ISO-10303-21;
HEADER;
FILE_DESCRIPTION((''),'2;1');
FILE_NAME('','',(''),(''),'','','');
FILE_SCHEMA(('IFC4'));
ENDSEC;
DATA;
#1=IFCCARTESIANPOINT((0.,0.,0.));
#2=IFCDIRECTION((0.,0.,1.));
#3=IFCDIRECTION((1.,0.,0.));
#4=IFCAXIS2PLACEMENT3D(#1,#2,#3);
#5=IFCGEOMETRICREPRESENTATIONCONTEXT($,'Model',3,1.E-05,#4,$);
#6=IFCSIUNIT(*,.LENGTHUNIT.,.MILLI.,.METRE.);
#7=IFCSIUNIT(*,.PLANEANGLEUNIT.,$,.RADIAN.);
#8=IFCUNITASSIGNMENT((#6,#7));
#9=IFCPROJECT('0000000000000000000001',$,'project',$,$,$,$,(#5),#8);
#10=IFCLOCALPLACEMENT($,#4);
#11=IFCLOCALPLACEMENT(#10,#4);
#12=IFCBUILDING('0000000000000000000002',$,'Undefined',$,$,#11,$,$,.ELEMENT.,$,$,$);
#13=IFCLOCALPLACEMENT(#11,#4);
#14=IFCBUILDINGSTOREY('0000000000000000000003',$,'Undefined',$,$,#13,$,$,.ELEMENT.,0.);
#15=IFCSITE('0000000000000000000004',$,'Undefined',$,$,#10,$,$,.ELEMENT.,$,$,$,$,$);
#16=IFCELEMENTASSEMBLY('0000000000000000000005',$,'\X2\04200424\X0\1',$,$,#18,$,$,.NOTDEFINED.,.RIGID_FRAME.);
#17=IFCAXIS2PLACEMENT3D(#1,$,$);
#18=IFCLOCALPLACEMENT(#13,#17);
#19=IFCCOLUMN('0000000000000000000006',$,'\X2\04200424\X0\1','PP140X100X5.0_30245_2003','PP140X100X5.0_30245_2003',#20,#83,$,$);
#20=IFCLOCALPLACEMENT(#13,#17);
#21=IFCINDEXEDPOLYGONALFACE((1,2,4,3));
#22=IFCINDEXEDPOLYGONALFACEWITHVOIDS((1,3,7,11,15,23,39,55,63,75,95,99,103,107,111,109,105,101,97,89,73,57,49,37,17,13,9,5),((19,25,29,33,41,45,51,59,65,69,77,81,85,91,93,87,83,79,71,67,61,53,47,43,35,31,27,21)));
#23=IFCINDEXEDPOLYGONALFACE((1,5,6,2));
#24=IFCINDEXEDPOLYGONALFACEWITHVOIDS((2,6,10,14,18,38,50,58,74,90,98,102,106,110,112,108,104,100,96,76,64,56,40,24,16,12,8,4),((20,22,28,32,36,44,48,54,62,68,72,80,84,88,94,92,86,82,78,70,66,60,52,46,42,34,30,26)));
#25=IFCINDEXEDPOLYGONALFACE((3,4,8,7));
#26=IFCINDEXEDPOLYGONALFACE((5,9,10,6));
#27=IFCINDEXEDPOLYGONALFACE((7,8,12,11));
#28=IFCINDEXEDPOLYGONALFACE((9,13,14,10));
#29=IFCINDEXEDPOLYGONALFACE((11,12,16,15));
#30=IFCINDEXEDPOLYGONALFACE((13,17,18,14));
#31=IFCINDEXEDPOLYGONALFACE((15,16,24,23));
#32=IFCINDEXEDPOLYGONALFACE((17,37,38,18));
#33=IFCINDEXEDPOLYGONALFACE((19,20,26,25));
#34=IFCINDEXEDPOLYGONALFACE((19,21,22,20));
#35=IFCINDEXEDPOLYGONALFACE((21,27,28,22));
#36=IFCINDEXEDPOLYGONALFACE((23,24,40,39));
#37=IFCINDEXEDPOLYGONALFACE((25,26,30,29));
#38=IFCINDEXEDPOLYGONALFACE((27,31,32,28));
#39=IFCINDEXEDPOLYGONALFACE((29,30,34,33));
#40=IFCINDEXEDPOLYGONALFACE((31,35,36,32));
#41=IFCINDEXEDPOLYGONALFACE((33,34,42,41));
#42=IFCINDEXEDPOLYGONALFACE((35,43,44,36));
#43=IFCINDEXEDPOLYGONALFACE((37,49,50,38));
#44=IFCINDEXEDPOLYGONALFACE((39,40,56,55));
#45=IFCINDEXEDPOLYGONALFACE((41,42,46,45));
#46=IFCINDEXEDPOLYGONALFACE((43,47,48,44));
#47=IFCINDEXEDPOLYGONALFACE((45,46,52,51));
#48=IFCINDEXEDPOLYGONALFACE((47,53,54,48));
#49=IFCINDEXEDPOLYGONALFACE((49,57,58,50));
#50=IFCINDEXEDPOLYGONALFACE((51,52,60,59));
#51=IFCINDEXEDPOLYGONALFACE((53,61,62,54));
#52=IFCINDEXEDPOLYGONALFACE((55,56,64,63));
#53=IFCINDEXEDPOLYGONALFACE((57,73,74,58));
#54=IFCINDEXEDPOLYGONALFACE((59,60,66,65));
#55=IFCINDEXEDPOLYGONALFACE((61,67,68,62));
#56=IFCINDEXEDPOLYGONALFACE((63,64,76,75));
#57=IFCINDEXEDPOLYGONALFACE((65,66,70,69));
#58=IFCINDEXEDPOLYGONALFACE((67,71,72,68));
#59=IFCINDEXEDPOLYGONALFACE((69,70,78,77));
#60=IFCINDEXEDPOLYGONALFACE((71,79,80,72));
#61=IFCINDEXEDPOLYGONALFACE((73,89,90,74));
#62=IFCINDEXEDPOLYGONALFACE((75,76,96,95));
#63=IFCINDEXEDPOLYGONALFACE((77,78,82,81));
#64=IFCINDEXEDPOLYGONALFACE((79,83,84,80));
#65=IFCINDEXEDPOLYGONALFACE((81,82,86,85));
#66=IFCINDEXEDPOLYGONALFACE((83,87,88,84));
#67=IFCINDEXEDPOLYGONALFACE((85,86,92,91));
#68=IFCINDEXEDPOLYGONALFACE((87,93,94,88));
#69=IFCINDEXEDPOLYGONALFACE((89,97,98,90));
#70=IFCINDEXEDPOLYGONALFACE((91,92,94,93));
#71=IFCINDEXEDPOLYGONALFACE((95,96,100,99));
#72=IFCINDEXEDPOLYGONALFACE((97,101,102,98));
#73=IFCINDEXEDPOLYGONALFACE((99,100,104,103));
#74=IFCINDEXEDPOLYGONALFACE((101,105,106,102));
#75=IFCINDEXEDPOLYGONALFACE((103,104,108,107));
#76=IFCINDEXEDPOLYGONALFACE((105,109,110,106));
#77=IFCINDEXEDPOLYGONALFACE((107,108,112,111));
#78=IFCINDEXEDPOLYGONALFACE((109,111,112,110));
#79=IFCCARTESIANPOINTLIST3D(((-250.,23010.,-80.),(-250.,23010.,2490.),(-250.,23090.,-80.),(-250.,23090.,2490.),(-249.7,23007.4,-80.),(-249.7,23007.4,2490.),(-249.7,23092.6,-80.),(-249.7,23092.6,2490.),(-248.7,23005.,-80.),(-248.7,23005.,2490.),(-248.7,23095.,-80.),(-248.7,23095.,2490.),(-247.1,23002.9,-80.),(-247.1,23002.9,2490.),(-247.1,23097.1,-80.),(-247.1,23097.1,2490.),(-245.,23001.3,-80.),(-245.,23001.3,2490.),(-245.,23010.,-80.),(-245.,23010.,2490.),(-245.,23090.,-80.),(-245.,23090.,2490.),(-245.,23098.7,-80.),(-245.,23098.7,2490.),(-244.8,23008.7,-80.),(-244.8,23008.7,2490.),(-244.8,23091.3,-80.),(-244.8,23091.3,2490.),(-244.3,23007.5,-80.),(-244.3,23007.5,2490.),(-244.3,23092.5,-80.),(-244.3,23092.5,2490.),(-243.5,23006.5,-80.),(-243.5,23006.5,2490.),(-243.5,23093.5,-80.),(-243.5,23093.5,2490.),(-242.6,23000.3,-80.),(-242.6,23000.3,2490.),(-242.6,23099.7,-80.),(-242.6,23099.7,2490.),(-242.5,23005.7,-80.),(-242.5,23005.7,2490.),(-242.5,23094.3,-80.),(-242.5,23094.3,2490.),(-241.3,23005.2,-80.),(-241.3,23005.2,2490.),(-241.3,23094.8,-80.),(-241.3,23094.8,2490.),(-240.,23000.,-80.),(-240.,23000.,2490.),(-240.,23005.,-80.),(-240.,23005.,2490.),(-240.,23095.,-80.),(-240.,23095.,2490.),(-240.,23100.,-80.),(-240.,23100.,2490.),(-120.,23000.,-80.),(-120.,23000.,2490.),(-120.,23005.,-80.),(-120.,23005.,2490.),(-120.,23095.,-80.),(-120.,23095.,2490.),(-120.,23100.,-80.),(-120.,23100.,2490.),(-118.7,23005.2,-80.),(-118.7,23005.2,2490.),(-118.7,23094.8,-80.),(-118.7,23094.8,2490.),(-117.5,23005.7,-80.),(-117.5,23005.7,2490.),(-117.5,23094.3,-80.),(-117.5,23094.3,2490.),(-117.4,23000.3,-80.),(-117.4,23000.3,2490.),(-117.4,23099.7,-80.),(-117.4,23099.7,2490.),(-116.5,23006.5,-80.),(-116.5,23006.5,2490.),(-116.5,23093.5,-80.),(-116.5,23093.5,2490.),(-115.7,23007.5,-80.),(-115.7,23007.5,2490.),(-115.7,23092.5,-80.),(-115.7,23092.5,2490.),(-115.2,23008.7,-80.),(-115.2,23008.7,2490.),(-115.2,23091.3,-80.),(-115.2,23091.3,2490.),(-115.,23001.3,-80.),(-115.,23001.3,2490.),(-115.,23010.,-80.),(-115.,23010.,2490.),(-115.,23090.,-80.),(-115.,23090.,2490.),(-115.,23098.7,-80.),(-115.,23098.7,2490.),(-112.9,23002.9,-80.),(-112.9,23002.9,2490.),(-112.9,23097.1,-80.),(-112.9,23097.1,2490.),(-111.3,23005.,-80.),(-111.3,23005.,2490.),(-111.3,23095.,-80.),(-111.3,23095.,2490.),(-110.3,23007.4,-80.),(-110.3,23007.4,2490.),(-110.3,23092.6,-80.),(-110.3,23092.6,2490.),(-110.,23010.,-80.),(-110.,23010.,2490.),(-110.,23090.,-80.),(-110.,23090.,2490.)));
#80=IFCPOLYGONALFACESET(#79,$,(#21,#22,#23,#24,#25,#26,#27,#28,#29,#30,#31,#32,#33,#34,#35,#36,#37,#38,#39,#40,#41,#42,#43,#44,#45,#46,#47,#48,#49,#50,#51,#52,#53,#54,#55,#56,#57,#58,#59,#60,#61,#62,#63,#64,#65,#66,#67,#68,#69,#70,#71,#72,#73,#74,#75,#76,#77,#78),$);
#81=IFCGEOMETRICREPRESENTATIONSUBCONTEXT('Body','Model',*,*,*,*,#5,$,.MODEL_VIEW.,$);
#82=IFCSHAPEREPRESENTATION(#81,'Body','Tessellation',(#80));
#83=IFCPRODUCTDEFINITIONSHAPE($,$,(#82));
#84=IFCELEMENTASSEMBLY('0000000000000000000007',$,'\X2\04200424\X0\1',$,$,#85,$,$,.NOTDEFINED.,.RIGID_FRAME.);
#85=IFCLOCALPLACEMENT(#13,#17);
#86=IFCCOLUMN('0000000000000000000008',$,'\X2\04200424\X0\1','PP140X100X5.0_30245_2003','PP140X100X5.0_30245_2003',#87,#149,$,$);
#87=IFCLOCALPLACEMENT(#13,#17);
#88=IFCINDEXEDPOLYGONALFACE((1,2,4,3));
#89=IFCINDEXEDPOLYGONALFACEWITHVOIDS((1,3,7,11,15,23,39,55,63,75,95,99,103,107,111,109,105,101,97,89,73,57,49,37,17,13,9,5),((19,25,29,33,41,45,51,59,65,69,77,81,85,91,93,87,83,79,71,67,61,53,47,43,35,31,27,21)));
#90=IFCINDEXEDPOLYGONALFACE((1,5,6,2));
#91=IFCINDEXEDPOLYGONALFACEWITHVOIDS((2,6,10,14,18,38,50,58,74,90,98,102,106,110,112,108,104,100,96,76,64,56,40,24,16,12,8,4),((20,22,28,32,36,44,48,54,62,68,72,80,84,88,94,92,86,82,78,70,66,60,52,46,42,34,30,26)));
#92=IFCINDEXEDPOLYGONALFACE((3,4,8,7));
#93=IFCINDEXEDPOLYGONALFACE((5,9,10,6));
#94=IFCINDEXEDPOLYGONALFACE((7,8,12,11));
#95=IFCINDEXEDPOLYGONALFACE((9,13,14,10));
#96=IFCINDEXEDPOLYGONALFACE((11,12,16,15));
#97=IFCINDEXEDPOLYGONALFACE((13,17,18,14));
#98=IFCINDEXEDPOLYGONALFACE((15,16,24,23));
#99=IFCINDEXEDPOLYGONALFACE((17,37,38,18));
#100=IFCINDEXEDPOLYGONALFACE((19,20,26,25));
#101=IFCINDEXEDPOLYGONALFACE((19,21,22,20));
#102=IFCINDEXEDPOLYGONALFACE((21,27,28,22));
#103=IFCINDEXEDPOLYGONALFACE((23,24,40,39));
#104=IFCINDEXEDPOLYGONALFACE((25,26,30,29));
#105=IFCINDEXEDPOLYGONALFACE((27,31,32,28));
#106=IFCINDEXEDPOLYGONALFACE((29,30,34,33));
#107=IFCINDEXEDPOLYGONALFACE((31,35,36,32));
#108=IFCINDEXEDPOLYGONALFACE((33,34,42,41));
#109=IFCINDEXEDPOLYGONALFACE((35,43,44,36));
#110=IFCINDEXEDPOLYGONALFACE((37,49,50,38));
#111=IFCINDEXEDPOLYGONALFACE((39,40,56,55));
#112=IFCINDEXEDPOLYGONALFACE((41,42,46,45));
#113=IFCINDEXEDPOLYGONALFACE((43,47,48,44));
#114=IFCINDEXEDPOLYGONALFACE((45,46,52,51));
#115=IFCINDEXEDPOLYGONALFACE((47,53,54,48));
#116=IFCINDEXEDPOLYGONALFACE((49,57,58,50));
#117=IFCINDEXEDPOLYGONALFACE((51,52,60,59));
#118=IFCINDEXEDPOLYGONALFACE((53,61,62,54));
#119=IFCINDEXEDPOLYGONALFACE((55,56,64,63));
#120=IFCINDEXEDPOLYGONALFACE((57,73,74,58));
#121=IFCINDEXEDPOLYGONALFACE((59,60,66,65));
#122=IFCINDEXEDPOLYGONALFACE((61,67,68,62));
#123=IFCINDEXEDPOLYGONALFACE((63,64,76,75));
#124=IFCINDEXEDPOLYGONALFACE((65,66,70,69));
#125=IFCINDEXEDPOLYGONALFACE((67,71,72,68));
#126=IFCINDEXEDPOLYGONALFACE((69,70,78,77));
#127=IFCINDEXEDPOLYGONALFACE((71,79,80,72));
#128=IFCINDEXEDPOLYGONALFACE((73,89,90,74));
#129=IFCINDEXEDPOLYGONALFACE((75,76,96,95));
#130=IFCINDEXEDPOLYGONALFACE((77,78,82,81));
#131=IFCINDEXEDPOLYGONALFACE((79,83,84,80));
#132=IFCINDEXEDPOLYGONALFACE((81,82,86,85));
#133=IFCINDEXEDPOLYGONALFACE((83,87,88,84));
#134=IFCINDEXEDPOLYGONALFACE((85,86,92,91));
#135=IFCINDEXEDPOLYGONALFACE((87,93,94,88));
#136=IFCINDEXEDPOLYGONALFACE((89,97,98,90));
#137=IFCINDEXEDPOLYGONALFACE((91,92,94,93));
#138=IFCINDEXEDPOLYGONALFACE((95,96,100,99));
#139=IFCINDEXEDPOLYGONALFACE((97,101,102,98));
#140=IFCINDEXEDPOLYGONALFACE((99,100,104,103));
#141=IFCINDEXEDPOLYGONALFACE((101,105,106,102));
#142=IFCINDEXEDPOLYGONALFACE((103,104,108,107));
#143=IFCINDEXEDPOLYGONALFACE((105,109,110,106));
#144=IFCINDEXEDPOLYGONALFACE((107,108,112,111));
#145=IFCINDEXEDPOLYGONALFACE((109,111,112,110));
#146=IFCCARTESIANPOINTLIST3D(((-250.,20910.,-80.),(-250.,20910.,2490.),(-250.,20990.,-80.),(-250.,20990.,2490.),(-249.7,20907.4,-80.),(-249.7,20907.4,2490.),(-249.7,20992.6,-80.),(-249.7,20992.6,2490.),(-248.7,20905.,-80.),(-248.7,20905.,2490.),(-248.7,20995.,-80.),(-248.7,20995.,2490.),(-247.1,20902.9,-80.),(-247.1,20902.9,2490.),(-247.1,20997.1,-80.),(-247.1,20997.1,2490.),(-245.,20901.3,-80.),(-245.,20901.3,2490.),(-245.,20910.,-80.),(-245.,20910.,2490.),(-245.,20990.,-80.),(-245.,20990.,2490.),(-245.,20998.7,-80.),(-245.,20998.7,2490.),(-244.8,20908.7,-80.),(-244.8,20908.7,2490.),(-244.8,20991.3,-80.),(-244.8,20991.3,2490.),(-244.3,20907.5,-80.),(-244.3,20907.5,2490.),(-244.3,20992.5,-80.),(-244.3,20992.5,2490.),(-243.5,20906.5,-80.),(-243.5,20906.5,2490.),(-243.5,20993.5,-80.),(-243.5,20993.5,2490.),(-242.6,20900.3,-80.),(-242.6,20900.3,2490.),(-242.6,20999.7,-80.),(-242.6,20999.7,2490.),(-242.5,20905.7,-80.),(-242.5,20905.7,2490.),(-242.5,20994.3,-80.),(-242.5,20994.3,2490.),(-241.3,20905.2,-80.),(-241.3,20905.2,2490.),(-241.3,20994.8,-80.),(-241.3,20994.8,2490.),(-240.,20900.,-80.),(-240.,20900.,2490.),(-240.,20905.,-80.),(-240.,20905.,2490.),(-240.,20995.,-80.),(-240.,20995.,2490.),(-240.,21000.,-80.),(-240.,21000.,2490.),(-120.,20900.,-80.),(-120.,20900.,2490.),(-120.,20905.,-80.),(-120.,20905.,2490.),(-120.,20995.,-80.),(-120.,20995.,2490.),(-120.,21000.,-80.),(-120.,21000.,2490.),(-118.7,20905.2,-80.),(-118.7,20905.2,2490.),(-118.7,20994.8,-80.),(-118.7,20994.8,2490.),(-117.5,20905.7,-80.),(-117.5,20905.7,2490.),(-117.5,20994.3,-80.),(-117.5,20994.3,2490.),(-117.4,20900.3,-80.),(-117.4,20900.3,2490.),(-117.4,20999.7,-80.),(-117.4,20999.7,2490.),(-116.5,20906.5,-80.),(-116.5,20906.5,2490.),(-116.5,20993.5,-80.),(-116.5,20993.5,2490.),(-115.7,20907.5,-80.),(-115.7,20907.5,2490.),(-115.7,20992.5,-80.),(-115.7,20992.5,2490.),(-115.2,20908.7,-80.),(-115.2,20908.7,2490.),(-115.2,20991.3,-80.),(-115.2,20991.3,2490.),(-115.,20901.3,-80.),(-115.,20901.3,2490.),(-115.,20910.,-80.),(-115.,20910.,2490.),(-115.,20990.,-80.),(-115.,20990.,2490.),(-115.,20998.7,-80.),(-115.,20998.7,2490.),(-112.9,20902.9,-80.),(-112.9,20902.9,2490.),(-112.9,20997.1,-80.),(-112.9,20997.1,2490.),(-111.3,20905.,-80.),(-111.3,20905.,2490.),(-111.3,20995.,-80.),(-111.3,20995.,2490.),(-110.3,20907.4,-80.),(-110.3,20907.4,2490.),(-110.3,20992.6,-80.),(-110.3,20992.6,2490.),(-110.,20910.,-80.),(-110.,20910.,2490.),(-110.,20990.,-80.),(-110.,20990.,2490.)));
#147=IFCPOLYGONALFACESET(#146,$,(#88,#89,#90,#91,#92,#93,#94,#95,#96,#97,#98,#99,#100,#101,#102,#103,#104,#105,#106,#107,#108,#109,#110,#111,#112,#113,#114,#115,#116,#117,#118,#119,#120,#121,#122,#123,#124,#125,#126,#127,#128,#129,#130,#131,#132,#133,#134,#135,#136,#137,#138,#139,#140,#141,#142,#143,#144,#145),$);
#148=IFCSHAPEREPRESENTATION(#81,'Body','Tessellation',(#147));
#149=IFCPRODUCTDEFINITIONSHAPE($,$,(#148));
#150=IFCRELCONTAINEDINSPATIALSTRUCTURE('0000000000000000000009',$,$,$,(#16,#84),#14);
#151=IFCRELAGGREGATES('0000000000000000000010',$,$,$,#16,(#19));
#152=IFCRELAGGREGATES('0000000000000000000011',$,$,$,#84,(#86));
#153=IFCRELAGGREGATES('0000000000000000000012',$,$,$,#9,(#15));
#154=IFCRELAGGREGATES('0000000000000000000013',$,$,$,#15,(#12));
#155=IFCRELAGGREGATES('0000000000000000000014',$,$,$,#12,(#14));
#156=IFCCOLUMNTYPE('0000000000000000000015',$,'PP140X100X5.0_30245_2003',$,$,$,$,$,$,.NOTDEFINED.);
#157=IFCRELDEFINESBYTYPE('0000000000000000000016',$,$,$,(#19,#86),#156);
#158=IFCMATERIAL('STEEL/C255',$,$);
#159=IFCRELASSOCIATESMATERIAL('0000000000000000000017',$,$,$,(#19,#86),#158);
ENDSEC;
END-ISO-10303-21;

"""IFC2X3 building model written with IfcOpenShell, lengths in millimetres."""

from ifc_helpers import new_model, si_unit, frame, origin_with_axes, origin_2d_with_axis, place, context, subcontext, project, spatial, hollow_rectangle, extrude, material, type_object, element, aggregate, save


model = new_model("IFC2X3")

# Units and contexts
model_context = context("Model", 3, precision=1e-05, world=origin_with_axes())
body_context = subcontext(model_context, "Body", "Model", "MODEL_VIEW")
ifc_project = project(units=[si_unit("LENGTHUNIT", "METRE", prefix="MILLI"), si_unit("PLANEANGLEUNIT", "RADIAN")], contexts=[model_context])

# Site, building, storey
site_placement = place(None, origin_with_axes())
site = spatial("IfcSite", under=ifc_project, at=site_placement, Name="Undefined", CompositionType="ELEMENT")
building_placement = place(site_placement, origin_with_axes())
building = spatial("IfcBuilding", under=site, at=building_placement, Name="Undefined", CompositionType="ELEMENT")
storey_placement = place(building_placement, origin_with_axes())
storey = spatial("IfcBuildingStorey", under=building, at=storey_placement, Name="Undefined", CompositionType="ELEMENT", Elevation=0.0)

# Element assemblies, columns
ifc_material_1 = material(Name="STEEL/C255")
assembly_1_placement = place(storey_placement, origin_with_axes())
assembly_1 = element("IfcElementAssembly", 1, at=assembly_1_placement, inside=storey, Name="РФ1", AssemblyPlace="NOTDEFINED", PredefinedType="RIGID_FRAME")
column_type_1 = type_object("IfcColumnType", Name="PP140X100X5.0_30245_2003", PredefinedType="NOTDEFINED")
column_1_placement = place(assembly_1_placement, frame((-180.0, 23050.0, -80.0), z_axis=(0.0, 0.0, 1.0), x_axis=(-1.0, 0.0, 0.0)))
column_1 = element("IfcColumn", 2, at=column_1_placement, type_object=column_type_1, material=ifc_material_1, Name="РФ1", Description="PP140X100X5.0_30245_2003", ObjectType="PP140X100X5.0_30245_2003", context=body_context, shape_type="SweptSolid", body=[
    extrude(hollow_rectangle(XDim=100.0, YDim=140.0, WallThickness=5.0, InnerFilletRadius=5.0, OuterFilletRadius=10.0, at=origin_2d_with_axis()), frame((0.0, 0.0, 2570.0), z_axis=(0.0, 0.0, -1.0), x_axis=(0.0, 1.0, 0.0)), (0.0, 0.0, 1.0), 2570.0),
])
aggregate(assembly_1, [column_1])
assembly_2_placement = place(storey_placement, origin_with_axes())
assembly_2 = element("IfcElementAssembly", 3, at=assembly_2_placement, inside=storey, Name="РФ1", AssemblyPlace="NOTDEFINED", PredefinedType="RIGID_FRAME")
column_2_placement = place(assembly_2_placement, frame((-180.0, 20950.0, -80.0), z_axis=(0.0, 0.0, 1.0), x_axis=(1.0, 0.0, 0.0)))
column_2 = element("IfcColumn", 4, at=column_2_placement, type_object=column_type_1, material=ifc_material_1, Name="РФ1", Description="PP140X100X5.0_30245_2003", ObjectType="PP140X100X5.0_30245_2003", context=body_context, shape_type="SweptSolid", body=[
    extrude(hollow_rectangle(XDim=100.0, YDim=140.0, WallThickness=5.0, InnerFilletRadius=5.0, OuterFilletRadius=10.0, at=origin_2d_with_axis()), frame((0.0, 0.0, 2570.0), z_axis=(0.0, 0.0, -1.0), x_axis=(0.0, 1.0, 0.0)), (0.0, 0.0, 1.0), 2570.0),
])
aggregate(assembly_2, [column_2])

save(model, "model.ifc")
